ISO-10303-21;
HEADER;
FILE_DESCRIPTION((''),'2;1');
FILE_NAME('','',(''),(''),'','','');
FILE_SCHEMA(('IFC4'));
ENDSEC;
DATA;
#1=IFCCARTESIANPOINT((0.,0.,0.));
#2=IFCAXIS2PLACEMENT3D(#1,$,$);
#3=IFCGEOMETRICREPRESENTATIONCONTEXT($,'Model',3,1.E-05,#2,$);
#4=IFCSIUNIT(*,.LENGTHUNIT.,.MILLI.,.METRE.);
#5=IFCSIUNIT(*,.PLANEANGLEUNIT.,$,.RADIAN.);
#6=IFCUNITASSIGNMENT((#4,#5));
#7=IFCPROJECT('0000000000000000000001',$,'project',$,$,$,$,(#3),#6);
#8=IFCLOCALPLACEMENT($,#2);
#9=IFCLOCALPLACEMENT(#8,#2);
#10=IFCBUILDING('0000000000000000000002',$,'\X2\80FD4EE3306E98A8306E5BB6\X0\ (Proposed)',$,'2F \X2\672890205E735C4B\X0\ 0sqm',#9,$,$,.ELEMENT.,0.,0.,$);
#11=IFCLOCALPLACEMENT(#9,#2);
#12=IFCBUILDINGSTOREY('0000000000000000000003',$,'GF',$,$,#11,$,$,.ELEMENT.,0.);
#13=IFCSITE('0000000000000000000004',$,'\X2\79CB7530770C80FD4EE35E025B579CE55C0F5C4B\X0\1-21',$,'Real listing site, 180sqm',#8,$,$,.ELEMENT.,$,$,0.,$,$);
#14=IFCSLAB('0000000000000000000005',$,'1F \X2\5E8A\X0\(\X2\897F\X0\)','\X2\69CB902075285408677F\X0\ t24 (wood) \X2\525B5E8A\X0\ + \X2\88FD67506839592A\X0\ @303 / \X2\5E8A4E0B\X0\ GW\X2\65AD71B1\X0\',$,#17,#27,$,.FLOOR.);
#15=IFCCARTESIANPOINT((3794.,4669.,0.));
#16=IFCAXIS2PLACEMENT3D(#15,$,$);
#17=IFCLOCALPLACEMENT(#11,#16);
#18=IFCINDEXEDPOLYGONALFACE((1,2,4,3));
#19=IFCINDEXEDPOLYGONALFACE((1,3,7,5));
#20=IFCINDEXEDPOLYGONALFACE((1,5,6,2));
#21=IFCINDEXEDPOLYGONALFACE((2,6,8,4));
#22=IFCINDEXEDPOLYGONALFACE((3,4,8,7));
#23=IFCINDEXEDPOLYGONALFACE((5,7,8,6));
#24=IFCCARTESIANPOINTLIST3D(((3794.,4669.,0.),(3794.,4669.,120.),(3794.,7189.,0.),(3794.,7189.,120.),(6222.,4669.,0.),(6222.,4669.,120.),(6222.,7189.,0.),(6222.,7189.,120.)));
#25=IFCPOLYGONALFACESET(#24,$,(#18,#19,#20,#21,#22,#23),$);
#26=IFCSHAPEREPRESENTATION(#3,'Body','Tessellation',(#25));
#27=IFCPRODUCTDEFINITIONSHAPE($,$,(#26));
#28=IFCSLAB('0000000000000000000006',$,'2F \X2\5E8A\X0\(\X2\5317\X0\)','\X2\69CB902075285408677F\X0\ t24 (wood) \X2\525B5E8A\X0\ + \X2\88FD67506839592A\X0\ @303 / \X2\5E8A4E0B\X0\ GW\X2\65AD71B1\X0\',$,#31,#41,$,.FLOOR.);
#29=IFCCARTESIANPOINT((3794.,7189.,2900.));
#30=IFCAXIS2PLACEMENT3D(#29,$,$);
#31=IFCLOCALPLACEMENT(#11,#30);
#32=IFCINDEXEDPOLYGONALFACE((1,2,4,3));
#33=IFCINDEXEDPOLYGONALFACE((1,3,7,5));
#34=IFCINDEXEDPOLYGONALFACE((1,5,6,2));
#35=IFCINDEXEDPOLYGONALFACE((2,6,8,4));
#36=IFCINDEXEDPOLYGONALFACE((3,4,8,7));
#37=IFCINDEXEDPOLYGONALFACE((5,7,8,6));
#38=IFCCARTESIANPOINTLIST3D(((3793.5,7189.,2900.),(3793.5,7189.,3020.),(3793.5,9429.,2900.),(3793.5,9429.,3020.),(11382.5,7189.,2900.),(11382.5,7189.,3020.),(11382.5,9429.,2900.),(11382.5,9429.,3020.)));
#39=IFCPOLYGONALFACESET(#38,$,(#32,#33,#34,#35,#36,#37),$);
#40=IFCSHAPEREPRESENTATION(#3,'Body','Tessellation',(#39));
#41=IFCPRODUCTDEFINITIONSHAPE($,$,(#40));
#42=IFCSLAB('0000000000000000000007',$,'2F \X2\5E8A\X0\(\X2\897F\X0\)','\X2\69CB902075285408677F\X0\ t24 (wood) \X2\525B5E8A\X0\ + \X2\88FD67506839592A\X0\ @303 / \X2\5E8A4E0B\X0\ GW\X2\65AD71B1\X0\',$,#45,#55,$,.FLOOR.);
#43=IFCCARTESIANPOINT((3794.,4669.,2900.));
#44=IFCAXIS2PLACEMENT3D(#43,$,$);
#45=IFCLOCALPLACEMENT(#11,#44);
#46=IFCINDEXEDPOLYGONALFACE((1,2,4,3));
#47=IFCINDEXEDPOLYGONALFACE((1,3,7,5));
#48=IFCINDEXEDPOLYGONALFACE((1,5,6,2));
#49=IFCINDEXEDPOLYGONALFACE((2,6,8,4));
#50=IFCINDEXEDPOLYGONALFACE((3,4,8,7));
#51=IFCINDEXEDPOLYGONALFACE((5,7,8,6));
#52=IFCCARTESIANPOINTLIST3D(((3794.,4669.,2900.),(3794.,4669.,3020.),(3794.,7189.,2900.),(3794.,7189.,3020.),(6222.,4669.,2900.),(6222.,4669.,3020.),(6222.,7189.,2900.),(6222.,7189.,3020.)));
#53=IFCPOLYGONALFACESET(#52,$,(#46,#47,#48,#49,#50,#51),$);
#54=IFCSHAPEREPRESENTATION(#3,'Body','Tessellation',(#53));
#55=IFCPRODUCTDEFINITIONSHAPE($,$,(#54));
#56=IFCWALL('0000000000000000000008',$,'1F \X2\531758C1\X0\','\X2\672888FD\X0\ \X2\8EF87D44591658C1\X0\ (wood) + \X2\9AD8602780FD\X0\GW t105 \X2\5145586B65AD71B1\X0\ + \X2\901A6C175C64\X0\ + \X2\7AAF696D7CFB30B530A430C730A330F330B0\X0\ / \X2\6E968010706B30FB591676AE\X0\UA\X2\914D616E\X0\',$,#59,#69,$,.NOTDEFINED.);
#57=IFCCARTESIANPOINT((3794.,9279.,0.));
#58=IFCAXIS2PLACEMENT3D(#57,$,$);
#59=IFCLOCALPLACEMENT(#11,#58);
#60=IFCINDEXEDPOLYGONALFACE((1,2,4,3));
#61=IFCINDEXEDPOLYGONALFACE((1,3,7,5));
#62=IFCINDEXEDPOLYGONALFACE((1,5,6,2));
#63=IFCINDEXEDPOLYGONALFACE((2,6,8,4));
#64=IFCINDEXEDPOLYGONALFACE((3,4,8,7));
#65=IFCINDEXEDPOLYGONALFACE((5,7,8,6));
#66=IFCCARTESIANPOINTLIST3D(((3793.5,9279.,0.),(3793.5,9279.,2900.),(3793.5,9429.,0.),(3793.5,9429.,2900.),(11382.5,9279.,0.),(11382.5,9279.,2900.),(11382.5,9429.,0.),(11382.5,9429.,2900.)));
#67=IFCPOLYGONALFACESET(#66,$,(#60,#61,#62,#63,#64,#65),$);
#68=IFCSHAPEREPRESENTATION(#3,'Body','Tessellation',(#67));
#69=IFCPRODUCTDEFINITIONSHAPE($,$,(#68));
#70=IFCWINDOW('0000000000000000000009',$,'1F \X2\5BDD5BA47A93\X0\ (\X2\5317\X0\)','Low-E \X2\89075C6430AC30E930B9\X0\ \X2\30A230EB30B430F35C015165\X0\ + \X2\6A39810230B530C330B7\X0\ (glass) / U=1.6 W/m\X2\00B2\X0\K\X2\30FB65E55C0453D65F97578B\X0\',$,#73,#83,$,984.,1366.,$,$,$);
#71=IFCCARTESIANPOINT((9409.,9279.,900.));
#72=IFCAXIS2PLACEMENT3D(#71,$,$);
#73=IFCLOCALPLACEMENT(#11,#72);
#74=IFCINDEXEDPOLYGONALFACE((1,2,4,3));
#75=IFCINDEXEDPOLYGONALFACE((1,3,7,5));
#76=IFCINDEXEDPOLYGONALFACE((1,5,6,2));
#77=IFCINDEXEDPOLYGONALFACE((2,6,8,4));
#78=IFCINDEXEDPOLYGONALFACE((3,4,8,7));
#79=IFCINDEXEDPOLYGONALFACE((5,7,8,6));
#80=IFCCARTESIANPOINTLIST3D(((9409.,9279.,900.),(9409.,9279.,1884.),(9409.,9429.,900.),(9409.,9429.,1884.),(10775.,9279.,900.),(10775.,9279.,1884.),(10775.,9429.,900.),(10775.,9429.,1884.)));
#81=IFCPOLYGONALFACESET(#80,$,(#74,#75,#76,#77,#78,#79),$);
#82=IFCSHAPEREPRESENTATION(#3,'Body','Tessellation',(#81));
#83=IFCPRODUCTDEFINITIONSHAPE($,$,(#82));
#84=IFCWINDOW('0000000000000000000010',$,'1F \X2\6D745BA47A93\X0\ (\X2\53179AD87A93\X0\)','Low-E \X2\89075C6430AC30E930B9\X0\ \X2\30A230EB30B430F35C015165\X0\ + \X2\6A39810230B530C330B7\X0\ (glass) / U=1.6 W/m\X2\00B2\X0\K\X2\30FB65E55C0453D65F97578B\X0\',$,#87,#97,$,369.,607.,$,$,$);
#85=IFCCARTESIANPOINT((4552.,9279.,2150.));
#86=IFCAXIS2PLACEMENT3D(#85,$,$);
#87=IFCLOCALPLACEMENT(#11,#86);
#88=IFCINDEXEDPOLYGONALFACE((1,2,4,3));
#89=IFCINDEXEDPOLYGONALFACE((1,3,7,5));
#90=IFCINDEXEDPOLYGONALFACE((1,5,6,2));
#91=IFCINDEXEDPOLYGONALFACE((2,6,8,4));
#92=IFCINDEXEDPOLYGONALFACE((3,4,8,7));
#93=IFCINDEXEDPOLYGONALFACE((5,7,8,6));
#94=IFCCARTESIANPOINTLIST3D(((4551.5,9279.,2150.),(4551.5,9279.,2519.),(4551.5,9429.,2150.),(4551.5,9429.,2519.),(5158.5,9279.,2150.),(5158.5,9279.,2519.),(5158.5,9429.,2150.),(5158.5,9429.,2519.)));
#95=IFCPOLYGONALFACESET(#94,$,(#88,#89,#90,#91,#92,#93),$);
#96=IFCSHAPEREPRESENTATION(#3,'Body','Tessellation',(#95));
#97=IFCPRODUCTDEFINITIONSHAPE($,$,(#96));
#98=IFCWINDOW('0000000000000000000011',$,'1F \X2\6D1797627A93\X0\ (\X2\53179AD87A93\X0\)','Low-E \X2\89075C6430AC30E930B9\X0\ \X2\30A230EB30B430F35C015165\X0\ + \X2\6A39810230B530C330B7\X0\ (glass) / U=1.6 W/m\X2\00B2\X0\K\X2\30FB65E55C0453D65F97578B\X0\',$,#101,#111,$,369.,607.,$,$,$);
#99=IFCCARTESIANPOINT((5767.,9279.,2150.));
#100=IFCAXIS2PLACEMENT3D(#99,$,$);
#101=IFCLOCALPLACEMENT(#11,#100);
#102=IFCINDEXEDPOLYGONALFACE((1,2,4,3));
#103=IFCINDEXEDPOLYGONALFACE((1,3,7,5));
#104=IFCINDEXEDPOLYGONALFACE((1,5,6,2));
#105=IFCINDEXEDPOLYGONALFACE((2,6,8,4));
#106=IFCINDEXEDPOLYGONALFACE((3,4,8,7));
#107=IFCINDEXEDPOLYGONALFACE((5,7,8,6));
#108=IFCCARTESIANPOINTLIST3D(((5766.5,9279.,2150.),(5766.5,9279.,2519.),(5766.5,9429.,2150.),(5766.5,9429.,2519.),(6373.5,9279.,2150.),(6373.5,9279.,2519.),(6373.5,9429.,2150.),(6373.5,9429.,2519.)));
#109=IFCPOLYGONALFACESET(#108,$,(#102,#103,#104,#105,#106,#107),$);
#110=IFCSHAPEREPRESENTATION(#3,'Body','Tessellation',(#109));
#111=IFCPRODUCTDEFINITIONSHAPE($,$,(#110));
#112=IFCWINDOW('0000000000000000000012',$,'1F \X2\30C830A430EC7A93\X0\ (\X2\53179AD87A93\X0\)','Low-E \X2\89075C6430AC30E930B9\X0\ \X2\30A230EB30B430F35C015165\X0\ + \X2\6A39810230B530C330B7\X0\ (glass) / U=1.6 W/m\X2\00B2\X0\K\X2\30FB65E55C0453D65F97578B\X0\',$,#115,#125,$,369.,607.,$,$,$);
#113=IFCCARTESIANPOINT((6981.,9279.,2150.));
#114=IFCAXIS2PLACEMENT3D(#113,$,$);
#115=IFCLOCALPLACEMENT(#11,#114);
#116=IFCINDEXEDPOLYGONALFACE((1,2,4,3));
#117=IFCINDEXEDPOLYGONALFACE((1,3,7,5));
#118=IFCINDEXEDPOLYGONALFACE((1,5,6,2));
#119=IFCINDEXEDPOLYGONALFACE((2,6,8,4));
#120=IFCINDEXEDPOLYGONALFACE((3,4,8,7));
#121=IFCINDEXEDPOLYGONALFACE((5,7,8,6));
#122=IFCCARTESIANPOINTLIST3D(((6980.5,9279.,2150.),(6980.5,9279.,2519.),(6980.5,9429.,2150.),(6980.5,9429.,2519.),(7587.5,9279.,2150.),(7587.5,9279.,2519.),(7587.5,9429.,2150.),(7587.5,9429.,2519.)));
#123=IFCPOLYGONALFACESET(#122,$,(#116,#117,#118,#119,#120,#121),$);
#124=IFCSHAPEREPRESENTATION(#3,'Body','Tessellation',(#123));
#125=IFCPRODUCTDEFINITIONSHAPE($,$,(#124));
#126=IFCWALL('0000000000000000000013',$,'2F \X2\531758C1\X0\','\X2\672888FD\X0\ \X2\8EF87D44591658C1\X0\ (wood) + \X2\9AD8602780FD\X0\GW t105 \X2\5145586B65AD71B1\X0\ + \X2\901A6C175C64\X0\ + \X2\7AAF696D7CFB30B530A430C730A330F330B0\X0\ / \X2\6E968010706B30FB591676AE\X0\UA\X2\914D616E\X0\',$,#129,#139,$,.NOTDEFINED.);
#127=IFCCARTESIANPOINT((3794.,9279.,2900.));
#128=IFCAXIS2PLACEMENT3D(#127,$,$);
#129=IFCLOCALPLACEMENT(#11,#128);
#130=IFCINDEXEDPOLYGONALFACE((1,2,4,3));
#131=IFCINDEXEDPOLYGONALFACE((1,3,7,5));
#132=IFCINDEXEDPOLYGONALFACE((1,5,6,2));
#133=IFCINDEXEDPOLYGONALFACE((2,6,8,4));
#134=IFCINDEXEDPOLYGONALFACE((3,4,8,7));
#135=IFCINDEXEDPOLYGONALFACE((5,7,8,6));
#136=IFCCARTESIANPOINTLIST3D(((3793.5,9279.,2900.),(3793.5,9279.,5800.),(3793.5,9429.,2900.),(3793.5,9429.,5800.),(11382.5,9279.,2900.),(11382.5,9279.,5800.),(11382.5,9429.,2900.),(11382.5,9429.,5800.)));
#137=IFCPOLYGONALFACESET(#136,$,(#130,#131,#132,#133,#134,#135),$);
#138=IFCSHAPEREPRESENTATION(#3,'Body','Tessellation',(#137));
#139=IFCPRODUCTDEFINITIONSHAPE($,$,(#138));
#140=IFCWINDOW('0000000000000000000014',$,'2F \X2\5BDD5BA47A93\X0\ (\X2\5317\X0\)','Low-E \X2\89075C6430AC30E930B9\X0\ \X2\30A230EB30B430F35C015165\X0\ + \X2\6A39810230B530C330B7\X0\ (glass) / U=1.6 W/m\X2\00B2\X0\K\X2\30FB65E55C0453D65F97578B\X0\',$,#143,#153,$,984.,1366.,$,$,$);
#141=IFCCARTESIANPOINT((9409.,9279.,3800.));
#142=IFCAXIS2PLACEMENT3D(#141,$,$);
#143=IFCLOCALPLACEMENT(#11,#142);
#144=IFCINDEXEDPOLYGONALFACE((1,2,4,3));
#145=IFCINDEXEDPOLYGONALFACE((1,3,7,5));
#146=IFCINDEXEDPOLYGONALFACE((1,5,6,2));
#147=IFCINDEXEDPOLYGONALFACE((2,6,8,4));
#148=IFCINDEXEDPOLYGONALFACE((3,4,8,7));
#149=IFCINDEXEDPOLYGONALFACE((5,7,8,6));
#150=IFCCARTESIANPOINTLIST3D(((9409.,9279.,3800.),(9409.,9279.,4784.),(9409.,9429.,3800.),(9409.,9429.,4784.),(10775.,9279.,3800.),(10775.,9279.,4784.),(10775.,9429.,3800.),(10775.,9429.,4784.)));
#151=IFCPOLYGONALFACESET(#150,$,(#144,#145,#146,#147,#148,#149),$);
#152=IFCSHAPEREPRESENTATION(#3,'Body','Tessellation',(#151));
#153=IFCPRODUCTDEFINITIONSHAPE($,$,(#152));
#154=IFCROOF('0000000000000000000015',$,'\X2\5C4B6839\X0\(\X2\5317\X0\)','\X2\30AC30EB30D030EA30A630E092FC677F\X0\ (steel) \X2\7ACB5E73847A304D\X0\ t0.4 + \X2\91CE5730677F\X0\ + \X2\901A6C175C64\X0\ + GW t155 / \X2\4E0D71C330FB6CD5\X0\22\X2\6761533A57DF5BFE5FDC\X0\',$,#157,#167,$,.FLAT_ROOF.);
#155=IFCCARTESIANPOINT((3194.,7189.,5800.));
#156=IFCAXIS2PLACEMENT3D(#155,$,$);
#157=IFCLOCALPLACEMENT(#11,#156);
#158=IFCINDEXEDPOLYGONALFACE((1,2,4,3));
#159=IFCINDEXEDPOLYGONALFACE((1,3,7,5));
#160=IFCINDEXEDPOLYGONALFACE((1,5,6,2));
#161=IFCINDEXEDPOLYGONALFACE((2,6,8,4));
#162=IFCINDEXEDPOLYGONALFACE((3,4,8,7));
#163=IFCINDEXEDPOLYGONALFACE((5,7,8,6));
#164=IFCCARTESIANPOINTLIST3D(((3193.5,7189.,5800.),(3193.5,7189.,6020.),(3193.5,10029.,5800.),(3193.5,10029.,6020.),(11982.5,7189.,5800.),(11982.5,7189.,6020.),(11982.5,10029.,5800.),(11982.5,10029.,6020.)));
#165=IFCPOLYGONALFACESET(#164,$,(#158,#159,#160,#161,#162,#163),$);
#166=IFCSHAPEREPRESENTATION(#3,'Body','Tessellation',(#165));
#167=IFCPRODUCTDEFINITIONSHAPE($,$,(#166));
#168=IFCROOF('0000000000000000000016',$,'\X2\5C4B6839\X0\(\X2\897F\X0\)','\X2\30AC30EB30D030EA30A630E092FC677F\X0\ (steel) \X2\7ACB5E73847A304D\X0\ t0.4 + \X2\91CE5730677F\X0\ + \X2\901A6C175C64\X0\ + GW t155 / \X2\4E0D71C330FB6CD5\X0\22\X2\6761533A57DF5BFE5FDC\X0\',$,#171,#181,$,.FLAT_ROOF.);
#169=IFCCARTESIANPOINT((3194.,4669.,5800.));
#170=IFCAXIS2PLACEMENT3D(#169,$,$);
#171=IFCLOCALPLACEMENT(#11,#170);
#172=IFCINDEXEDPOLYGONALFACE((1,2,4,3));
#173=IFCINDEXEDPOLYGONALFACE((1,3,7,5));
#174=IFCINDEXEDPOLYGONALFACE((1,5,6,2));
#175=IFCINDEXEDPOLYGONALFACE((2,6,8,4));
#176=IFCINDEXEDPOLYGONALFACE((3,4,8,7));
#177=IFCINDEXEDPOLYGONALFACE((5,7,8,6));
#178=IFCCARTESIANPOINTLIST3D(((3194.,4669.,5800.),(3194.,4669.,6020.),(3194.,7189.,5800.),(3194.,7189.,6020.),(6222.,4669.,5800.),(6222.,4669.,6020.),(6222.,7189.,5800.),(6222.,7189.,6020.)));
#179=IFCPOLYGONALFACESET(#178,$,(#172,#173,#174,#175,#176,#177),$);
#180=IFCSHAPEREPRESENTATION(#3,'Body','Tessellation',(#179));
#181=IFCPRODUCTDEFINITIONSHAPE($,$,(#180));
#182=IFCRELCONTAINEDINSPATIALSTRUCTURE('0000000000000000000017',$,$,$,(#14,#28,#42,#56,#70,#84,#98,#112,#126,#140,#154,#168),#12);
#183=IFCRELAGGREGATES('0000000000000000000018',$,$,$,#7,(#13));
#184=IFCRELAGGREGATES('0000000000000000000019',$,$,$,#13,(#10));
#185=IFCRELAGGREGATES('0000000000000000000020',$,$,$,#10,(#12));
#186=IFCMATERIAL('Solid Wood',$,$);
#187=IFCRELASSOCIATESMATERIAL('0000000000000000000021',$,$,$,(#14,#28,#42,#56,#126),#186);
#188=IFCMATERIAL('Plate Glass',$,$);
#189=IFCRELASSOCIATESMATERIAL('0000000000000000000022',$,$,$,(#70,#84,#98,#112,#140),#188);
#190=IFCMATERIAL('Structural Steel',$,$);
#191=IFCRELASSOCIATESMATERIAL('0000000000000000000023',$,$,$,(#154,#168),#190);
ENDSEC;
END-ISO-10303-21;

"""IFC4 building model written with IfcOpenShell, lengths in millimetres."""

from ifc_helpers import new_model, si_unit, frame, frame_2d, origin, place, context, project, spatial, rectangle, extrude, material, element, fill, save


model = new_model("IFC4")

# Units and contexts
model_context = context("Model", 3, precision=1e-05, world=origin())
ifc_project = project(units=[si_unit("LENGTHUNIT", "METRE", prefix="MILLI"), si_unit("PLANEANGLEUNIT", "RADIAN")], contexts=[model_context])

# Site, building, storey
site_placement = place(None, origin())
site = spatial("IfcSite", under=ifc_project, at=site_placement, Name="秋田県能代市字鳥小屋1-21", ObjectType="Real listing site, 180sqm", CompositionType="ELEMENT", RefElevation=0.0)
building_placement = place(site_placement, origin())
building = spatial("IfcBuilding", under=site, at=building_placement, Name="能代の風の家 (Proposed)", ObjectType="2F 木造平屋 0sqm", CompositionType="ELEMENT", ElevationOfRefHeight=0.0, ElevationOfTerrain=0.0)
storey_placement = place(building_placement, origin())
storey = spatial("IfcBuildingStorey", under=building, at=storey_placement, Name="GF", CompositionType="ELEMENT", Elevation=0.0)

# Slabs
ifc_material_1 = material(Name="Solid Wood")
slab_1_placement = place(storey_placement, frame((3794.0, 4669.0, 0.0)))
element("IfcSlab", 1, at=slab_1_placement, inside=storey, material=ifc_material_1, Name="1F 床(西)", Description="構造用合板 t24 (wood) 剛床 + 製材根太 @303 / 床下 GW断熱", PredefinedType="FLOOR", context=model_context, shape_type="SweptSolid", body=[
    extrude(rectangle(XDim=2428.0, YDim=2520.0, at=frame_2d((1214.0, 1260.0))), frame((3794.0, 4669.0, 0.0)), (0.0, 0.0, 1.0), 120.0),
])
slab_2_placement = place(storey_placement, frame((3794.0, 7189.0, 2900.0)))
element("IfcSlab", 2, at=slab_2_placement, inside=storey, material=ifc_material_1, Name="2F 床(北)", Description="構造用合板 t24 (wood) 剛床 + 製材根太 @303 / 床下 GW断熱", PredefinedType="FLOOR", context=model_context, shape_type="SweptSolid", body=[
    extrude(rectangle(XDim=7589.0, YDim=2240.0, at=frame_2d((3794.0, 1120.0))), frame((3794.0, 7189.0, 2900.0)), (0.0, 0.0, 1.0), 120.0),
])
slab_3_placement = place(storey_placement, frame((3794.0, 4669.0, 2900.0)))
element("IfcSlab", 3, at=slab_3_placement, inside=storey, material=ifc_material_1, Name="2F 床(西)", Description="構造用合板 t24 (wood) 剛床 + 製材根太 @303 / 床下 GW断熱", PredefinedType="FLOOR", context=model_context, shape_type="SweptSolid", body=[
    extrude(rectangle(XDim=2428.0, YDim=2520.0, at=frame_2d((1214.0, 1260.0))), frame((3794.0, 4669.0, 2900.0)), (0.0, 0.0, 1.0), 120.0),
])

# Wall, openings, windows
wall_1_placement = place(storey_placement, frame((3794.0, 9279.0, 0.0)))
wall_1 = element("IfcWall", 4, at=wall_1_placement, inside=storey, material=ifc_material_1, Name="1F 北壁", Description="木製 軸組外壁 (wood) + 高性能GW t105 充填断熱 + 通気層 + 窯業系サイディング / 準耐火・外皮UA配慮", PredefinedType="NOTDEFINED", context=model_context, shape_type="SweptSolid", body=[
    extrude(rectangle(XDim=7589.0, YDim=150.0, at=frame_2d((3794.0, 75.0))), frame((3794.0, 9279.0, 0.0)), (0.0, 0.0, 1.0), 2900.0),
])
opening_1_placement = place(storey_placement, frame((9409.0, 9279.0, 900.0)))
opening_1 = element("IfcOpeningElement", 5, at=opening_1_placement, cuts=wall_1, PredefinedType="NOTDEFINED", context=model_context, shape_type="SweptSolid", body=[
    extrude(rectangle(XDim=1366.0, YDim=150.0, at=frame_2d((683.0, 75.0))), frame((9409.0, 9279.0, 900.0)), (0.0, 0.0, 1.0), 984.0),
])
opening_2_placement = place(storey_placement, frame((4552.0, 9279.0, 2150.0)))
opening_2 = element("IfcOpeningElement", 6, at=opening_2_placement, cuts=wall_1, PredefinedType="NOTDEFINED", context=model_context, shape_type="SweptSolid", body=[
    extrude(rectangle(XDim=607.0, YDim=150.0, at=frame_2d((303.0, 75.0))), frame((4552.0, 9279.0, 2150.0)), (0.0, 0.0, 1.0), 369.0),
])
opening_3_placement = place(storey_placement, frame((5767.0, 9279.0, 2150.0)))
opening_3 = element("IfcOpeningElement", 7, at=opening_3_placement, cuts=wall_1, PredefinedType="NOTDEFINED", context=model_context, shape_type="SweptSolid", body=[
    extrude(rectangle(XDim=607.0, YDim=150.0, at=frame_2d((303.0, 75.0))), frame((5767.0, 9279.0, 2150.0)), (0.0, 0.0, 1.0), 369.0),
])
opening_4_placement = place(storey_placement, frame((6981.0, 9279.0, 2150.0)))
opening_4 = element("IfcOpeningElement", 8, at=opening_4_placement, cuts=wall_1, PredefinedType="NOTDEFINED", context=model_context, shape_type="SweptSolid", body=[
    extrude(rectangle(XDim=607.0, YDim=150.0, at=frame_2d((303.0, 75.0))), frame((6981.0, 9279.0, 2150.0)), (0.0, 0.0, 1.0), 369.0),
])
ifc_material_2 = material(Name="Plate Glass")
window_1_placement = place(storey_placement, frame((9409.0, 9279.0, 900.0)))
window_1 = element("IfcWindow", 9, at=window_1_placement, inside=storey, material=ifc_material_2, Name="1F 寝室窓 (北)", Description="Low-E 複層ガラス アルゴン封入 + 樹脂サッシ (glass) / U=1.6 W/m²K・日射取得型", OverallHeight=984.0, OverallWidth=1366.0, context=model_context, shape_type="SweptSolid", body=[
    extrude(rectangle(XDim=1366.0, YDim=150.0, at=frame_2d((683.0, 75.0))), frame((9409.0, 9279.0, 900.0)), (0.0, 0.0, 1.0), 984.0),
])
fill(opening_1, window_1)
window_2_placement = place(storey_placement, frame((4552.0, 9279.0, 2150.0)))
window_2 = element("IfcWindow", 10, at=window_2_placement, inside=storey, material=ifc_material_2, Name="1F 浴室窓 (北高窓)", Description="Low-E 複層ガラス アルゴン封入 + 樹脂サッシ (glass) / U=1.6 W/m²K・日射取得型", OverallHeight=369.0, OverallWidth=607.0, context=model_context, shape_type="SweptSolid", body=[
    extrude(rectangle(XDim=607.0, YDim=150.0, at=frame_2d((303.0, 75.0))), frame((4552.0, 9279.0, 2150.0)), (0.0, 0.0, 1.0), 369.0),
])
fill(opening_2, window_2)
window_3_placement = place(storey_placement, frame((5767.0, 9279.0, 2150.0)))
window_3 = element("IfcWindow", 11, at=window_3_placement, inside=storey, material=ifc_material_2, Name="1F 洗面窓 (北高窓)", Description="Low-E 複層ガラス アルゴン封入 + 樹脂サッシ (glass) / U=1.6 W/m²K・日射取得型", OverallHeight=369.0, OverallWidth=607.0, context=model_context, shape_type="SweptSolid", body=[
    extrude(rectangle(XDim=607.0, YDim=150.0, at=frame_2d((303.0, 75.0))), frame((5767.0, 9279.0, 2150.0)), (0.0, 0.0, 1.0), 369.0),
])
fill(opening_3, window_3)
window_4_placement = place(storey_placement, frame((6981.0, 9279.0, 2150.0)))
window_4 = element("IfcWindow", 12, at=window_4_placement, inside=storey, material=ifc_material_2, Name="1F トイレ窓 (北高窓)", Description="Low-E 複層ガラス アルゴン封入 + 樹脂サッシ (glass) / U=1.6 W/m²K・日射取得型", OverallHeight=369.0, OverallWidth=607.0, context=model_context, shape_type="SweptSolid", body=[
    extrude(rectangle(XDim=607.0, YDim=150.0, at=frame_2d((303.0, 75.0))), frame((6981.0, 9279.0, 2150.0)), (0.0, 0.0, 1.0), 369.0),
])
fill(opening_4, window_4)

# Wall, opening, window
wall_2_placement = place(storey_placement, frame((3794.0, 9279.0, 2900.0)))
wall_2 = element("IfcWall", 13, at=wall_2_placement, inside=storey, material=ifc_material_1, Name="2F 北壁", Description="木製 軸組外壁 (wood) + 高性能GW t105 充填断熱 + 通気層 + 窯業系サイディング / 準耐火・外皮UA配慮", PredefinedType="NOTDEFINED", context=model_context, shape_type="SweptSolid", body=[
    extrude(rectangle(XDim=7589.0, YDim=150.0, at=frame_2d((3794.0, 75.0))), frame((3794.0, 9279.0, 2900.0)), (0.0, 0.0, 1.0), 2900.0),
])
opening_5_placement = place(storey_placement, frame((9409.0, 9279.0, 3800.0)))
opening_5 = element("IfcOpeningElement", 14, at=opening_5_placement, cuts=wall_2, PredefinedType="NOTDEFINED", context=model_context, shape_type="SweptSolid", body=[
    extrude(rectangle(XDim=1366.0, YDim=150.0, at=frame_2d((683.0, 75.0))), frame((9409.0, 9279.0, 3800.0)), (0.0, 0.0, 1.0), 984.0),
])
window_5_placement = place(storey_placement, frame((9409.0, 9279.0, 3800.0)))
window_5 = element("IfcWindow", 15, at=window_5_placement, inside=storey, material=ifc_material_2, Name="2F 寝室窓 (北)", Description="Low-E 複層ガラス アルゴン封入 + 樹脂サッシ (glass) / U=1.6 W/m²K・日射取得型", OverallHeight=984.0, OverallWidth=1366.0, context=model_context, shape_type="SweptSolid", body=[
    extrude(rectangle(XDim=1366.0, YDim=150.0, at=frame_2d((683.0, 75.0))), frame((9409.0, 9279.0, 3800.0)), (0.0, 0.0, 1.0), 984.0),
])
fill(opening_5, window_5)

# Roofs
ifc_material_3 = material(Name="Structural Steel")
for number, where, name in (
    (16, (3194.0, 7189.0, 5800.0), "屋根(北)"),
):
    element("IfcRoof", number, at=place(storey_placement, frame(where)), inside=storey, material=ifc_material_3, Name=name, Description="ガルバリウム鋼板 (steel) 立平葺き t0.4 + 野地板 + 通気層 + GW t155 / 不燃・法22条区域対応", PredefinedType="FLAT_ROOF", context=model_context, shape_type="SweptSolid", body=[
        extrude(rectangle(XDim=8789.0, YDim=2840.0, at=frame_2d((4394.0, 1420.0))), frame((3194.0, 7189.0, 5800.0)), (0.0, 0.0, 1.0), 220.0),
    ])
roof_placement = place(storey_placement, frame((3194.0, 4669.0, 5800.0)))
element("IfcRoof", 17, at=roof_placement, inside=storey, material=ifc_material_3, Name="屋根(西)", Description="ガルバリウム鋼板 (steel) 立平葺き t0.4 + 野地板 + 通気層 + GW t155 / 不燃・法22条区域対応", PredefinedType="FLAT_ROOF", context=model_context, shape_type="SweptSolid", body=[
    extrude(rectangle(XDim=3028.0, YDim=2520.0, at=frame_2d((1514.0, 1260.0))), frame((3194.0, 4669.0, 5800.0)), (0.0, 0.0, 1.0), 220.0),
])

save(model, "model.ifc")
